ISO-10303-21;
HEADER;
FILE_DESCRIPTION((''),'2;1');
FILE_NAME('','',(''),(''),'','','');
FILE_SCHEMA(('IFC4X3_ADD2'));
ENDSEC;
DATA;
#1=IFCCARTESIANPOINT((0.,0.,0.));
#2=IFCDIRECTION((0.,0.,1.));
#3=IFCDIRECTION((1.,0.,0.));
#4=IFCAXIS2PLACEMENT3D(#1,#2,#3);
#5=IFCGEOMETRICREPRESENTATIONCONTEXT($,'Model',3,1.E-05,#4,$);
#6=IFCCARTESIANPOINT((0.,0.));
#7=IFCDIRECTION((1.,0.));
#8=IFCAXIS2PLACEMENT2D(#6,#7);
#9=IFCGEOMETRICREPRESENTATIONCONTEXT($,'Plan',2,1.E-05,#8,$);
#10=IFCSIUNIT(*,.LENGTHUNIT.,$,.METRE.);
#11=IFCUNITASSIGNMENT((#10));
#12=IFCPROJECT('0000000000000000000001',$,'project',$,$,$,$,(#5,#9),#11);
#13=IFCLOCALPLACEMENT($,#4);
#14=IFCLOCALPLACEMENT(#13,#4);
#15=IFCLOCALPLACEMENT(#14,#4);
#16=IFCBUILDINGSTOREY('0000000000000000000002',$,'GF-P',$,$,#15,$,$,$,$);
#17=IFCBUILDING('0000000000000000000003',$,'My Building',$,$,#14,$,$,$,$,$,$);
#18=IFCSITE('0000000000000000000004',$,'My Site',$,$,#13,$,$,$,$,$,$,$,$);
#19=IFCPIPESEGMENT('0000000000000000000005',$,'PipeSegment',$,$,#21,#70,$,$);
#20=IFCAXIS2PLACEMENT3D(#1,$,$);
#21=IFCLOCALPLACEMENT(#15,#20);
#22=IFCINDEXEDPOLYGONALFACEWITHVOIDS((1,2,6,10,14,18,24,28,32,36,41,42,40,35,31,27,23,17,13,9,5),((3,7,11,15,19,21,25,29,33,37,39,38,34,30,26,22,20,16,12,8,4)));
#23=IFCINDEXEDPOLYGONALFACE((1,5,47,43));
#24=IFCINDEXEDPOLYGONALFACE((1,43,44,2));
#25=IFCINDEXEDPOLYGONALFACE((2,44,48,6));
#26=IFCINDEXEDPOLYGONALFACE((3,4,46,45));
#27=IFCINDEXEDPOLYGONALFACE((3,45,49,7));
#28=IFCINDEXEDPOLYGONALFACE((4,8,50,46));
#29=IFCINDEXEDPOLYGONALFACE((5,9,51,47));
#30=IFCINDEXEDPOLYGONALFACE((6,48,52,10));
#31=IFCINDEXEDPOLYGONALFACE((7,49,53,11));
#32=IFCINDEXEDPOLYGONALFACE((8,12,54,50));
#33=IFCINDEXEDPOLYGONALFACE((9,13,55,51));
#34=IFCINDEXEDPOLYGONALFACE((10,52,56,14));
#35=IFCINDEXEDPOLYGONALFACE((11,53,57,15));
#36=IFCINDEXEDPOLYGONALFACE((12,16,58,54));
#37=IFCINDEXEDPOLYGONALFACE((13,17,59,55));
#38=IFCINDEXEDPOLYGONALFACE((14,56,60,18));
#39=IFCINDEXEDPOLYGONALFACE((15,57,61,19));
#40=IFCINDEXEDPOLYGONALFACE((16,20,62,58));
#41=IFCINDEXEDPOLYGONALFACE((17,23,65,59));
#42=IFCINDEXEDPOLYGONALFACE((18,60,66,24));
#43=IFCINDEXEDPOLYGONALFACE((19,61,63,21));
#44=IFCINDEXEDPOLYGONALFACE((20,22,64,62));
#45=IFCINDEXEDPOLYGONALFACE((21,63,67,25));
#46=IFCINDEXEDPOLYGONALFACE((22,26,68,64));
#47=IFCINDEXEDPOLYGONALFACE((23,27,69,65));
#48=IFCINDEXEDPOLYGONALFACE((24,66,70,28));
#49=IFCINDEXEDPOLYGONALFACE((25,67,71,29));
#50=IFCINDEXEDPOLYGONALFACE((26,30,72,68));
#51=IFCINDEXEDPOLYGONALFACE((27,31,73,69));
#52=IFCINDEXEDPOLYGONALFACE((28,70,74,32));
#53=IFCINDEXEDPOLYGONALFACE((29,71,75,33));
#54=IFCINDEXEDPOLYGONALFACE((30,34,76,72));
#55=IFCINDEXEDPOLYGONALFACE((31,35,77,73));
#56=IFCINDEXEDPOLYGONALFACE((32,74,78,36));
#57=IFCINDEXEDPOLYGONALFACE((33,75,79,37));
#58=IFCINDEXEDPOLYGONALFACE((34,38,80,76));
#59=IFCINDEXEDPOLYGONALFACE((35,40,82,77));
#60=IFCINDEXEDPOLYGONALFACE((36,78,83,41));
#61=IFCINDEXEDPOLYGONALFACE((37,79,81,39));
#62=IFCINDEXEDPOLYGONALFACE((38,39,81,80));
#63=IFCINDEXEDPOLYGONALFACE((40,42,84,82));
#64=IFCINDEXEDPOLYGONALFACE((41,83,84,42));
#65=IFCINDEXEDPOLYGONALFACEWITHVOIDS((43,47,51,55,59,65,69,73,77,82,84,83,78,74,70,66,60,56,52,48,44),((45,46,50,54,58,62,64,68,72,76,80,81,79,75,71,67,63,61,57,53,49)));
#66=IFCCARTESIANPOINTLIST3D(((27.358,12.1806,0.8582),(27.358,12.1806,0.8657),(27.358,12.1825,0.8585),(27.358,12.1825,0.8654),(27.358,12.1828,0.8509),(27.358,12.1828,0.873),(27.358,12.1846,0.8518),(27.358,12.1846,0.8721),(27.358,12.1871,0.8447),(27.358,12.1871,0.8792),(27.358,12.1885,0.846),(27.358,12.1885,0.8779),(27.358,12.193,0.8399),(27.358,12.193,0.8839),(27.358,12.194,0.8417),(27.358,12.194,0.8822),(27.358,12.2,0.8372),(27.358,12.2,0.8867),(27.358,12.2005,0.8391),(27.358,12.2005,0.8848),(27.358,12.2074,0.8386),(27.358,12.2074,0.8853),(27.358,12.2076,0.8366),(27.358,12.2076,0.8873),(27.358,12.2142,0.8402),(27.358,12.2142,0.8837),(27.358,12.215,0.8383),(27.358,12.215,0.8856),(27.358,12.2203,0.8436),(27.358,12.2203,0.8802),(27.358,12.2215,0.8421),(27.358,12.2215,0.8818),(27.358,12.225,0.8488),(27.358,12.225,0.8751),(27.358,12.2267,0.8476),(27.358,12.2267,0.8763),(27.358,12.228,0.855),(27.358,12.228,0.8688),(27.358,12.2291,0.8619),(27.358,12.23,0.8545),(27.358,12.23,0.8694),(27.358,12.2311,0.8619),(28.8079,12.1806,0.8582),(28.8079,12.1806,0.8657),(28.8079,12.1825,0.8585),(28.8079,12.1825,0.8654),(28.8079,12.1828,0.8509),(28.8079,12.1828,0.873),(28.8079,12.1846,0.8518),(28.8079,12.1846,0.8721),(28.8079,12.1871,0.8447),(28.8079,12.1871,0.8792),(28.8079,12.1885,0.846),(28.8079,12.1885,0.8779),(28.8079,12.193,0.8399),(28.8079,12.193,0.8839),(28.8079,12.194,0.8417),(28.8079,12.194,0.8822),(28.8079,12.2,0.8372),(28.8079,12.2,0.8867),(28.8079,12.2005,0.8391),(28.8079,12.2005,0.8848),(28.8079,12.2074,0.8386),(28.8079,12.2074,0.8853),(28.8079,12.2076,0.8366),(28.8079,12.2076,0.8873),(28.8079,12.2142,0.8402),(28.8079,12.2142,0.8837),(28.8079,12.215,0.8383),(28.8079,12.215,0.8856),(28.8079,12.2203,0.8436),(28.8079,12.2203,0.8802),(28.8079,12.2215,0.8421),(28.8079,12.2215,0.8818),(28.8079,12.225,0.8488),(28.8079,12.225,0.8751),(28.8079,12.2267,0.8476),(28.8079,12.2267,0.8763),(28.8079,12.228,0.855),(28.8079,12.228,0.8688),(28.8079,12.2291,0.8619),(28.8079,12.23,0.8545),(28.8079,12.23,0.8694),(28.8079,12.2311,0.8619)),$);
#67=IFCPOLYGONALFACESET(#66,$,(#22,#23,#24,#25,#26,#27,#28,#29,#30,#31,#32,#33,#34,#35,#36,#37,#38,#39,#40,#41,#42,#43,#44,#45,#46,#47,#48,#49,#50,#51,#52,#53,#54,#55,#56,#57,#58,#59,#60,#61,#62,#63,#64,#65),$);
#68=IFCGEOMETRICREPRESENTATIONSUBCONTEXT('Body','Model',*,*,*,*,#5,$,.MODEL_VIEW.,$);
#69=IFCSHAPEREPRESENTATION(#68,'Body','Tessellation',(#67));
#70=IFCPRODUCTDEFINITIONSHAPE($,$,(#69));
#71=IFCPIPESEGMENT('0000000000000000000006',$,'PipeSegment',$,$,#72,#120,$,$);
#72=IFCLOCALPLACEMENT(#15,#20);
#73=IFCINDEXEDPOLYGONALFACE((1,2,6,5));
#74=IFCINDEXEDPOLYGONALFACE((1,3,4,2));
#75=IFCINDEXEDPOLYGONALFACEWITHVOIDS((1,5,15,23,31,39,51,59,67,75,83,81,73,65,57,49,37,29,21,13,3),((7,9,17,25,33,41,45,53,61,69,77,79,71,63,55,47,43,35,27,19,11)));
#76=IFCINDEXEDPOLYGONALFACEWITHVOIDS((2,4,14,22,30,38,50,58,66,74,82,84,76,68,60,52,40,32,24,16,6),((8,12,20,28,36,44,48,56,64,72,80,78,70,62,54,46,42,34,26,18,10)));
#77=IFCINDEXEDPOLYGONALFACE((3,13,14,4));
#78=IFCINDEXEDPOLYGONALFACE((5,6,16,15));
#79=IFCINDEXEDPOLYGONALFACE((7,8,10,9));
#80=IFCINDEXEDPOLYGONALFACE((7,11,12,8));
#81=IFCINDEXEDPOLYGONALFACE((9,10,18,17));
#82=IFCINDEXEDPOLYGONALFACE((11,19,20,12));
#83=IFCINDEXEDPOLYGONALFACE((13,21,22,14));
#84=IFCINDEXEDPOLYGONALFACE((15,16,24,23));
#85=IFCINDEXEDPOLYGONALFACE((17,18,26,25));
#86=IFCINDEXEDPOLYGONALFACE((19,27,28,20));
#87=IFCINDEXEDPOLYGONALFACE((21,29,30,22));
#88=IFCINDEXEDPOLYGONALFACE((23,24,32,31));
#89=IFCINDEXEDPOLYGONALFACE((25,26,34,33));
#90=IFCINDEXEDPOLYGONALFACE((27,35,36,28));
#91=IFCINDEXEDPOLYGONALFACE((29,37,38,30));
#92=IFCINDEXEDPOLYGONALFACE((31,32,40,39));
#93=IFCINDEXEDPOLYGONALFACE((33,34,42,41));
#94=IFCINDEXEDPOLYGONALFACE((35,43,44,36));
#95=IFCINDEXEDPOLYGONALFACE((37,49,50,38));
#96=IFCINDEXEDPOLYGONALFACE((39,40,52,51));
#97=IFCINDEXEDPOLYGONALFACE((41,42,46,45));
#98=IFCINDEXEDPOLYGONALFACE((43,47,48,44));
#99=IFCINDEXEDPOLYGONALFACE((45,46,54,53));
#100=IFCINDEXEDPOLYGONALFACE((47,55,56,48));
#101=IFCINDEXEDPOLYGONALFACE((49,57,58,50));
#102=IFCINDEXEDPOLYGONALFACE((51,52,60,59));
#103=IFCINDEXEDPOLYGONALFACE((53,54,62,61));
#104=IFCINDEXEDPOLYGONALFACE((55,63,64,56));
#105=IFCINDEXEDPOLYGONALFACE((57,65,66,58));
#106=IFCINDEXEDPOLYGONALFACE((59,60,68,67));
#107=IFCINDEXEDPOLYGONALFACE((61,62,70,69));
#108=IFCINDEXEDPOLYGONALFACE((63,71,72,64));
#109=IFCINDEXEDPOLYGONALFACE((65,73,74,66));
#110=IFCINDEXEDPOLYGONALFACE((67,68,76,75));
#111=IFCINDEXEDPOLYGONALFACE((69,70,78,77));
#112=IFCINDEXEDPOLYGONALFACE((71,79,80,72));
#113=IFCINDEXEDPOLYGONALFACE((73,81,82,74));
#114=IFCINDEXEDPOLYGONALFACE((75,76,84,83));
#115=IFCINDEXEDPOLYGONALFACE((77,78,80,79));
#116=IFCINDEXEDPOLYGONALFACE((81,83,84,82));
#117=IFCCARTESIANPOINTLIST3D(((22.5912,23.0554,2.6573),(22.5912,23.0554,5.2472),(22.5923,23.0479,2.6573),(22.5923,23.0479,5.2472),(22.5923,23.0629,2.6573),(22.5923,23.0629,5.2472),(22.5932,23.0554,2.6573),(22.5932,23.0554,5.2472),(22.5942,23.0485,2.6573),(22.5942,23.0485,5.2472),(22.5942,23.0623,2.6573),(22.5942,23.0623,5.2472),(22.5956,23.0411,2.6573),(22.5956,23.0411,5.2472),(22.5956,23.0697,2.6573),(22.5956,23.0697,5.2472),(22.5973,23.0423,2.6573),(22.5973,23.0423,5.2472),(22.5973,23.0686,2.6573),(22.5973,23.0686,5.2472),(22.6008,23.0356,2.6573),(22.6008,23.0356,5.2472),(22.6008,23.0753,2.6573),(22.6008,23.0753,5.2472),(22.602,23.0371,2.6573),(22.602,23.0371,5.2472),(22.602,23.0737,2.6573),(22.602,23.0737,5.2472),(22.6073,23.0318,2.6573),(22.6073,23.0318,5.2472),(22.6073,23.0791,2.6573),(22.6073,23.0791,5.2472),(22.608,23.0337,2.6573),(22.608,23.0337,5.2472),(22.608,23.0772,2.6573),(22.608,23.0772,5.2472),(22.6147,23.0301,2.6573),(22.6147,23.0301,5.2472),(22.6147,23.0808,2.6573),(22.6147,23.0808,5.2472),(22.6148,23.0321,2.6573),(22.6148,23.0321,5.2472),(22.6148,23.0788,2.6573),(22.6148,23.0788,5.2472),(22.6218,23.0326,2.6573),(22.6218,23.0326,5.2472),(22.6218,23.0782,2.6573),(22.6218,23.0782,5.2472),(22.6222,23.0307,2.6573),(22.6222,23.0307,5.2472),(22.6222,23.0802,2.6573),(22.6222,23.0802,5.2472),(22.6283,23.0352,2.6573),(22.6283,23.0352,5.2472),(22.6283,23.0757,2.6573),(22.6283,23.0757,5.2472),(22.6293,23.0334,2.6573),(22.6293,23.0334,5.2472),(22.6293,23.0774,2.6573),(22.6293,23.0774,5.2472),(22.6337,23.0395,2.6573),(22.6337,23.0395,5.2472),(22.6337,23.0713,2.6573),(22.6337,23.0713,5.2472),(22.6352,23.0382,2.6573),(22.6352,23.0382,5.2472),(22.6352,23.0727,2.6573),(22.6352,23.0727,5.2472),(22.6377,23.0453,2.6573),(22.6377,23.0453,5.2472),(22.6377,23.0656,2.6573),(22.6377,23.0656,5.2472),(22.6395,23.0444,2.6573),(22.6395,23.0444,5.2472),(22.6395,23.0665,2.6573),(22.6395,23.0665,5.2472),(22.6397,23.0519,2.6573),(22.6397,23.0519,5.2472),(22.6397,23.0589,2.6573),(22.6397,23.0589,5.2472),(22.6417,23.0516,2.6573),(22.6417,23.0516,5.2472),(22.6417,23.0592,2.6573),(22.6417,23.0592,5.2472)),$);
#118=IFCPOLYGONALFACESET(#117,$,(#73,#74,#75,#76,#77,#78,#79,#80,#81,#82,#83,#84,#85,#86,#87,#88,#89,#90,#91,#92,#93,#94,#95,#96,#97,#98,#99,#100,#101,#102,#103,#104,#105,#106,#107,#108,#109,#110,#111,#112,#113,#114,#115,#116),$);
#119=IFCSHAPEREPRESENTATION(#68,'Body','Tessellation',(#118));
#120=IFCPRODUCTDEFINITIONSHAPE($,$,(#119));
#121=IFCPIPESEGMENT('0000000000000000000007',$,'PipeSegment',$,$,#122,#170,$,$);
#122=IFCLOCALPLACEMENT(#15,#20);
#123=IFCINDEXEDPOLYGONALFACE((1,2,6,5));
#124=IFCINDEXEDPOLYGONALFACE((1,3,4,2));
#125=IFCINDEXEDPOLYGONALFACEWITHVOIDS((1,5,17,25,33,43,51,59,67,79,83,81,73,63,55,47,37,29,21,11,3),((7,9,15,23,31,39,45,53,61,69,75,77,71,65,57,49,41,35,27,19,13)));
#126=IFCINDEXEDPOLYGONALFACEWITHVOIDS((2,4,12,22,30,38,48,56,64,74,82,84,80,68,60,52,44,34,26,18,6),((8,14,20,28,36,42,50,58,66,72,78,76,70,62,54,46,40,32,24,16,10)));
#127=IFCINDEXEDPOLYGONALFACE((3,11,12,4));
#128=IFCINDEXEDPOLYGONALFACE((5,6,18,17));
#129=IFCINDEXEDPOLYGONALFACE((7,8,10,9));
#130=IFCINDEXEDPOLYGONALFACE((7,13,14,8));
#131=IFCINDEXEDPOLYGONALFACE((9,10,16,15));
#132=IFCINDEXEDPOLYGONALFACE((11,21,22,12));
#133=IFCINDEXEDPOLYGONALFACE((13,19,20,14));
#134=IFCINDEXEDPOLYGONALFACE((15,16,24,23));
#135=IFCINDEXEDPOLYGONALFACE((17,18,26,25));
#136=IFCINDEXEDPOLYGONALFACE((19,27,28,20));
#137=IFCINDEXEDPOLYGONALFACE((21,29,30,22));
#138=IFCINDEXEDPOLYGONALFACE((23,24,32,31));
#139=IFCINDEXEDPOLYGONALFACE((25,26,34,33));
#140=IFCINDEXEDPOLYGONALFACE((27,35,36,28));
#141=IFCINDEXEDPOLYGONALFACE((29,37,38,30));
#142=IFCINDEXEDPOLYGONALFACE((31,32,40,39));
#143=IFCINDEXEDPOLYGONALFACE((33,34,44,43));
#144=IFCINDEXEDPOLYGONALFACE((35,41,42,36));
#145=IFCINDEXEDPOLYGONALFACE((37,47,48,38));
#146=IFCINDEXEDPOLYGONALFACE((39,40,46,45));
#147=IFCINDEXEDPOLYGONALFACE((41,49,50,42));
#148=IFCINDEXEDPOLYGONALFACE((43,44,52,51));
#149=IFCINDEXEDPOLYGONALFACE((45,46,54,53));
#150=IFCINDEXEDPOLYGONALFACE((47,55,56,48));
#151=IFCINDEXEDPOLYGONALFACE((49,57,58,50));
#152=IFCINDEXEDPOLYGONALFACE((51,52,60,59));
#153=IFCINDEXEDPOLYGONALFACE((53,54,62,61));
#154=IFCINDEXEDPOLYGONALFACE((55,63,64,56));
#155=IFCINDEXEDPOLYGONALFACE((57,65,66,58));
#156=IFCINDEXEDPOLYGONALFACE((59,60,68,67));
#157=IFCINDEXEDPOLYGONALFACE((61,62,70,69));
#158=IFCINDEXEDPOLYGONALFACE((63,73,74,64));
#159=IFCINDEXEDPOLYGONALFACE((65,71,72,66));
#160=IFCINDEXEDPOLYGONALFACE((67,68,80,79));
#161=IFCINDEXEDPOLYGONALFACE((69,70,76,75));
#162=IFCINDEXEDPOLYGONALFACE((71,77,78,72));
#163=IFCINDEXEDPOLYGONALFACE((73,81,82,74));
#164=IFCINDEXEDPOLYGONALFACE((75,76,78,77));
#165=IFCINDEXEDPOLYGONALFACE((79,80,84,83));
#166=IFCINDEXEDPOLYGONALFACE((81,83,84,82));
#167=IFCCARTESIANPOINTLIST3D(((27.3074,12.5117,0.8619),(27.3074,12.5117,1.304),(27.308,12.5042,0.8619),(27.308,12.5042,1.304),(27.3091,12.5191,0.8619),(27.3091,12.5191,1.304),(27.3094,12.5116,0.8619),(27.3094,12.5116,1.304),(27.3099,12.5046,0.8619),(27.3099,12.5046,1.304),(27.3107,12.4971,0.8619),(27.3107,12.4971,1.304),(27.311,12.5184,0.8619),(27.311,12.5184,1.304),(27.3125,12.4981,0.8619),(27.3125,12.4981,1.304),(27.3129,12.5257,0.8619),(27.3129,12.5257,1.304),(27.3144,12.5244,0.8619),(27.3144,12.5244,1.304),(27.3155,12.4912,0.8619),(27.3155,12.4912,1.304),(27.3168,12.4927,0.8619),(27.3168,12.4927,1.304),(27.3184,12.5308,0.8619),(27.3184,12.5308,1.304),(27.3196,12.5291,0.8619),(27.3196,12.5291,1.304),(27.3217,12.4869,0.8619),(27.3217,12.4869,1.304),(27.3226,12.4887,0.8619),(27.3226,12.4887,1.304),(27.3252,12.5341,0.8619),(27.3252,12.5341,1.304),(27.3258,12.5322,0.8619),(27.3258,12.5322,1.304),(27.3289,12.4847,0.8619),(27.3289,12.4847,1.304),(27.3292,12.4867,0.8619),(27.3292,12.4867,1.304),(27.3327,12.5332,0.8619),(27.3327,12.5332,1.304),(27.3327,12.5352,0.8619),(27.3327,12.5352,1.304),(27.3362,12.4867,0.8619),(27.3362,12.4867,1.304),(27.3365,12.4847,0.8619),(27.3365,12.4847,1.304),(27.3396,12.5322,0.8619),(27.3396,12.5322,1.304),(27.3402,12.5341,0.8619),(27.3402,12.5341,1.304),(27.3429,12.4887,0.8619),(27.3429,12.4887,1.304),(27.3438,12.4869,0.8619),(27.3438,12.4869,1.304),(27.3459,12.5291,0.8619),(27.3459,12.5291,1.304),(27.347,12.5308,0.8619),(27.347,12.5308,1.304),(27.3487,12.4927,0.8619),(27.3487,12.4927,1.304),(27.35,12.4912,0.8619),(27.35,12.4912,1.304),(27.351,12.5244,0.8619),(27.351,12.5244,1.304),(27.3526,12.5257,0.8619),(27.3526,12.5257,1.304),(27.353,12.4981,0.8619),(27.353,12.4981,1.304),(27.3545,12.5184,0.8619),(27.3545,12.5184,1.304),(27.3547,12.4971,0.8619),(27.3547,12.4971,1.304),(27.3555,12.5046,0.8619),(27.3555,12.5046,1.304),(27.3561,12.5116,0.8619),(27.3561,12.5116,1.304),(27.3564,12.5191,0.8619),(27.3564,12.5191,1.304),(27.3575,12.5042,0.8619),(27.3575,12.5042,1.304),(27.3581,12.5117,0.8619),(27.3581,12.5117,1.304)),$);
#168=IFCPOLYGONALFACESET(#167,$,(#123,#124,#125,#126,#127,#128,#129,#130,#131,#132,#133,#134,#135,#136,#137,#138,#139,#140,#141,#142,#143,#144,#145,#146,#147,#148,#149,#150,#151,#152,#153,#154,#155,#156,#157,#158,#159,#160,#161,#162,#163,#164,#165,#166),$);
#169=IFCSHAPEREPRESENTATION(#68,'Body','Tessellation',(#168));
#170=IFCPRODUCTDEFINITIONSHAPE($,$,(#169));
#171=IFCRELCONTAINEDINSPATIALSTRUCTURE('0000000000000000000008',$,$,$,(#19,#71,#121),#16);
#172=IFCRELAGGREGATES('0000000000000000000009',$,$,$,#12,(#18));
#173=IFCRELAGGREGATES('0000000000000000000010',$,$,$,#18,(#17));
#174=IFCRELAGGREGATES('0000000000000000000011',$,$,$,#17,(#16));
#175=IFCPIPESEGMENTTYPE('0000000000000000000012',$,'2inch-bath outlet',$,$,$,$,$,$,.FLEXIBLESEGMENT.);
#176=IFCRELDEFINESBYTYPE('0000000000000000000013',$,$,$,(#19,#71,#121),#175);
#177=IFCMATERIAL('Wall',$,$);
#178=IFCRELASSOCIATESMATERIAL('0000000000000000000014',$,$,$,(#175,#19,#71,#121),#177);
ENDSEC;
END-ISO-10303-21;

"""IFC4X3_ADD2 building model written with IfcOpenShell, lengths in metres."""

from ifc_helpers import new_model, si_unit, frame, origin_with_axes, origin_2d_with_axis, place, context, subcontext, project, spatial, hollow_circle, extrude, material, material_profile, profile_set, profile_usage, type_object, element, save


model = new_model("IFC4X3_ADD2")

# Units and contexts
model_context = context("Model", 3, precision=1e-05, world=origin_with_axes())
plan_context = context("Plan", 2, precision=1e-05, world=origin_2d_with_axis())
body_context = subcontext(model_context, "Body", "Model", "MODEL_VIEW")
ifc_project = project(units=[si_unit("LENGTHUNIT", "METRE")], contexts=[model_context, plan_context])

# Site, building, storey
site_placement = place(None, origin_with_axes())
site = spatial("IfcSite", under=ifc_project, at=site_placement, Name="My Site")
building_placement = place(site_placement, origin_with_axes())
building = spatial("IfcBuilding", under=site, at=building_placement, Name="My Building")
storey_placement = place(building_placement, origin_with_axes())
storey = spatial("IfcBuildingStorey", under=building, at=storey_placement, Name="GF-P")

# Pipe segments
ifc_material_1 = material(Name="Wall")
ifc_material_profile_1 = material_profile(ifc_material_1, hollow_circle(Radius=0.0254, WallThickness=0.002))
ifc_profile_set_1 = profile_set([ifc_material_profile_1], Name="graywater")
pipe_segment_type_1 = type_object("IfcPipeSegmentType", Name="2inch-bath outlet", PredefinedType="FLEXIBLESEGMENT", material=ifc_profile_set_1)
ifc_profile_usage_1 = profile_usage(ifc_profile_set_1, cardinal=5)
pipe_segment_1_placement = place(storey_placement, frame((27.358, 12.2057, 0.8619), z_axis=(1.0, 0.0, 0.0), x_axis=(0.0, 1.0, 0.0)))
element("IfcPipeSegment", 1, at=pipe_segment_1_placement, inside=storey, type_object=pipe_segment_type_1, material=ifc_profile_usage_1, Name="PipeSegment", context=body_context, shape_type="SweptSolid", body=[
    extrude(hollow_circle(Radius=0.0254, WallThickness=0.002), origin_with_axes(), (0.0, 0.0, 1.0), 1.4499),
])
ifc_profile_usage_2 = profile_usage(ifc_profile_set_1)
pipe_segment_2_placement = place(storey_placement, frame((22.6166, 23.0554, 2.6573), z_axis=(0.0, 0.0, 1.0), x_axis=(-1.0, 0.0, 0.0)))
element("IfcPipeSegment", 2, at=pipe_segment_2_placement, inside=storey, type_object=pipe_segment_type_1, material=ifc_profile_usage_2, Name="PipeSegment", context=body_context, shape_type="SweptSolid", body=[
    extrude(hollow_circle(Radius=0.0254, WallThickness=0.002), origin_with_axes(), (0.0, 0.0, 1.0), 2.5899),
])
ifc_profile_usage_3 = profile_usage(ifc_profile_set_1, cardinal=5)
pipe_segment_3_placement = place(storey_placement, frame((27.3327, 12.5098, 0.8619), z_axis=(0.0, 0.0, 1.0), x_axis=(0.0, 1.0, 0.0)))
element("IfcPipeSegment", 3, at=pipe_segment_3_placement, inside=storey, type_object=pipe_segment_type_1, material=ifc_profile_usage_3, Name="PipeSegment", context=body_context, shape_type="SweptSolid", body=[
    extrude(hollow_circle(Radius=0.0254, WallThickness=0.002), origin_with_axes(), (0.0, 0.0, 1.0), 0.4421),
])

save(model, "model.ifc")
